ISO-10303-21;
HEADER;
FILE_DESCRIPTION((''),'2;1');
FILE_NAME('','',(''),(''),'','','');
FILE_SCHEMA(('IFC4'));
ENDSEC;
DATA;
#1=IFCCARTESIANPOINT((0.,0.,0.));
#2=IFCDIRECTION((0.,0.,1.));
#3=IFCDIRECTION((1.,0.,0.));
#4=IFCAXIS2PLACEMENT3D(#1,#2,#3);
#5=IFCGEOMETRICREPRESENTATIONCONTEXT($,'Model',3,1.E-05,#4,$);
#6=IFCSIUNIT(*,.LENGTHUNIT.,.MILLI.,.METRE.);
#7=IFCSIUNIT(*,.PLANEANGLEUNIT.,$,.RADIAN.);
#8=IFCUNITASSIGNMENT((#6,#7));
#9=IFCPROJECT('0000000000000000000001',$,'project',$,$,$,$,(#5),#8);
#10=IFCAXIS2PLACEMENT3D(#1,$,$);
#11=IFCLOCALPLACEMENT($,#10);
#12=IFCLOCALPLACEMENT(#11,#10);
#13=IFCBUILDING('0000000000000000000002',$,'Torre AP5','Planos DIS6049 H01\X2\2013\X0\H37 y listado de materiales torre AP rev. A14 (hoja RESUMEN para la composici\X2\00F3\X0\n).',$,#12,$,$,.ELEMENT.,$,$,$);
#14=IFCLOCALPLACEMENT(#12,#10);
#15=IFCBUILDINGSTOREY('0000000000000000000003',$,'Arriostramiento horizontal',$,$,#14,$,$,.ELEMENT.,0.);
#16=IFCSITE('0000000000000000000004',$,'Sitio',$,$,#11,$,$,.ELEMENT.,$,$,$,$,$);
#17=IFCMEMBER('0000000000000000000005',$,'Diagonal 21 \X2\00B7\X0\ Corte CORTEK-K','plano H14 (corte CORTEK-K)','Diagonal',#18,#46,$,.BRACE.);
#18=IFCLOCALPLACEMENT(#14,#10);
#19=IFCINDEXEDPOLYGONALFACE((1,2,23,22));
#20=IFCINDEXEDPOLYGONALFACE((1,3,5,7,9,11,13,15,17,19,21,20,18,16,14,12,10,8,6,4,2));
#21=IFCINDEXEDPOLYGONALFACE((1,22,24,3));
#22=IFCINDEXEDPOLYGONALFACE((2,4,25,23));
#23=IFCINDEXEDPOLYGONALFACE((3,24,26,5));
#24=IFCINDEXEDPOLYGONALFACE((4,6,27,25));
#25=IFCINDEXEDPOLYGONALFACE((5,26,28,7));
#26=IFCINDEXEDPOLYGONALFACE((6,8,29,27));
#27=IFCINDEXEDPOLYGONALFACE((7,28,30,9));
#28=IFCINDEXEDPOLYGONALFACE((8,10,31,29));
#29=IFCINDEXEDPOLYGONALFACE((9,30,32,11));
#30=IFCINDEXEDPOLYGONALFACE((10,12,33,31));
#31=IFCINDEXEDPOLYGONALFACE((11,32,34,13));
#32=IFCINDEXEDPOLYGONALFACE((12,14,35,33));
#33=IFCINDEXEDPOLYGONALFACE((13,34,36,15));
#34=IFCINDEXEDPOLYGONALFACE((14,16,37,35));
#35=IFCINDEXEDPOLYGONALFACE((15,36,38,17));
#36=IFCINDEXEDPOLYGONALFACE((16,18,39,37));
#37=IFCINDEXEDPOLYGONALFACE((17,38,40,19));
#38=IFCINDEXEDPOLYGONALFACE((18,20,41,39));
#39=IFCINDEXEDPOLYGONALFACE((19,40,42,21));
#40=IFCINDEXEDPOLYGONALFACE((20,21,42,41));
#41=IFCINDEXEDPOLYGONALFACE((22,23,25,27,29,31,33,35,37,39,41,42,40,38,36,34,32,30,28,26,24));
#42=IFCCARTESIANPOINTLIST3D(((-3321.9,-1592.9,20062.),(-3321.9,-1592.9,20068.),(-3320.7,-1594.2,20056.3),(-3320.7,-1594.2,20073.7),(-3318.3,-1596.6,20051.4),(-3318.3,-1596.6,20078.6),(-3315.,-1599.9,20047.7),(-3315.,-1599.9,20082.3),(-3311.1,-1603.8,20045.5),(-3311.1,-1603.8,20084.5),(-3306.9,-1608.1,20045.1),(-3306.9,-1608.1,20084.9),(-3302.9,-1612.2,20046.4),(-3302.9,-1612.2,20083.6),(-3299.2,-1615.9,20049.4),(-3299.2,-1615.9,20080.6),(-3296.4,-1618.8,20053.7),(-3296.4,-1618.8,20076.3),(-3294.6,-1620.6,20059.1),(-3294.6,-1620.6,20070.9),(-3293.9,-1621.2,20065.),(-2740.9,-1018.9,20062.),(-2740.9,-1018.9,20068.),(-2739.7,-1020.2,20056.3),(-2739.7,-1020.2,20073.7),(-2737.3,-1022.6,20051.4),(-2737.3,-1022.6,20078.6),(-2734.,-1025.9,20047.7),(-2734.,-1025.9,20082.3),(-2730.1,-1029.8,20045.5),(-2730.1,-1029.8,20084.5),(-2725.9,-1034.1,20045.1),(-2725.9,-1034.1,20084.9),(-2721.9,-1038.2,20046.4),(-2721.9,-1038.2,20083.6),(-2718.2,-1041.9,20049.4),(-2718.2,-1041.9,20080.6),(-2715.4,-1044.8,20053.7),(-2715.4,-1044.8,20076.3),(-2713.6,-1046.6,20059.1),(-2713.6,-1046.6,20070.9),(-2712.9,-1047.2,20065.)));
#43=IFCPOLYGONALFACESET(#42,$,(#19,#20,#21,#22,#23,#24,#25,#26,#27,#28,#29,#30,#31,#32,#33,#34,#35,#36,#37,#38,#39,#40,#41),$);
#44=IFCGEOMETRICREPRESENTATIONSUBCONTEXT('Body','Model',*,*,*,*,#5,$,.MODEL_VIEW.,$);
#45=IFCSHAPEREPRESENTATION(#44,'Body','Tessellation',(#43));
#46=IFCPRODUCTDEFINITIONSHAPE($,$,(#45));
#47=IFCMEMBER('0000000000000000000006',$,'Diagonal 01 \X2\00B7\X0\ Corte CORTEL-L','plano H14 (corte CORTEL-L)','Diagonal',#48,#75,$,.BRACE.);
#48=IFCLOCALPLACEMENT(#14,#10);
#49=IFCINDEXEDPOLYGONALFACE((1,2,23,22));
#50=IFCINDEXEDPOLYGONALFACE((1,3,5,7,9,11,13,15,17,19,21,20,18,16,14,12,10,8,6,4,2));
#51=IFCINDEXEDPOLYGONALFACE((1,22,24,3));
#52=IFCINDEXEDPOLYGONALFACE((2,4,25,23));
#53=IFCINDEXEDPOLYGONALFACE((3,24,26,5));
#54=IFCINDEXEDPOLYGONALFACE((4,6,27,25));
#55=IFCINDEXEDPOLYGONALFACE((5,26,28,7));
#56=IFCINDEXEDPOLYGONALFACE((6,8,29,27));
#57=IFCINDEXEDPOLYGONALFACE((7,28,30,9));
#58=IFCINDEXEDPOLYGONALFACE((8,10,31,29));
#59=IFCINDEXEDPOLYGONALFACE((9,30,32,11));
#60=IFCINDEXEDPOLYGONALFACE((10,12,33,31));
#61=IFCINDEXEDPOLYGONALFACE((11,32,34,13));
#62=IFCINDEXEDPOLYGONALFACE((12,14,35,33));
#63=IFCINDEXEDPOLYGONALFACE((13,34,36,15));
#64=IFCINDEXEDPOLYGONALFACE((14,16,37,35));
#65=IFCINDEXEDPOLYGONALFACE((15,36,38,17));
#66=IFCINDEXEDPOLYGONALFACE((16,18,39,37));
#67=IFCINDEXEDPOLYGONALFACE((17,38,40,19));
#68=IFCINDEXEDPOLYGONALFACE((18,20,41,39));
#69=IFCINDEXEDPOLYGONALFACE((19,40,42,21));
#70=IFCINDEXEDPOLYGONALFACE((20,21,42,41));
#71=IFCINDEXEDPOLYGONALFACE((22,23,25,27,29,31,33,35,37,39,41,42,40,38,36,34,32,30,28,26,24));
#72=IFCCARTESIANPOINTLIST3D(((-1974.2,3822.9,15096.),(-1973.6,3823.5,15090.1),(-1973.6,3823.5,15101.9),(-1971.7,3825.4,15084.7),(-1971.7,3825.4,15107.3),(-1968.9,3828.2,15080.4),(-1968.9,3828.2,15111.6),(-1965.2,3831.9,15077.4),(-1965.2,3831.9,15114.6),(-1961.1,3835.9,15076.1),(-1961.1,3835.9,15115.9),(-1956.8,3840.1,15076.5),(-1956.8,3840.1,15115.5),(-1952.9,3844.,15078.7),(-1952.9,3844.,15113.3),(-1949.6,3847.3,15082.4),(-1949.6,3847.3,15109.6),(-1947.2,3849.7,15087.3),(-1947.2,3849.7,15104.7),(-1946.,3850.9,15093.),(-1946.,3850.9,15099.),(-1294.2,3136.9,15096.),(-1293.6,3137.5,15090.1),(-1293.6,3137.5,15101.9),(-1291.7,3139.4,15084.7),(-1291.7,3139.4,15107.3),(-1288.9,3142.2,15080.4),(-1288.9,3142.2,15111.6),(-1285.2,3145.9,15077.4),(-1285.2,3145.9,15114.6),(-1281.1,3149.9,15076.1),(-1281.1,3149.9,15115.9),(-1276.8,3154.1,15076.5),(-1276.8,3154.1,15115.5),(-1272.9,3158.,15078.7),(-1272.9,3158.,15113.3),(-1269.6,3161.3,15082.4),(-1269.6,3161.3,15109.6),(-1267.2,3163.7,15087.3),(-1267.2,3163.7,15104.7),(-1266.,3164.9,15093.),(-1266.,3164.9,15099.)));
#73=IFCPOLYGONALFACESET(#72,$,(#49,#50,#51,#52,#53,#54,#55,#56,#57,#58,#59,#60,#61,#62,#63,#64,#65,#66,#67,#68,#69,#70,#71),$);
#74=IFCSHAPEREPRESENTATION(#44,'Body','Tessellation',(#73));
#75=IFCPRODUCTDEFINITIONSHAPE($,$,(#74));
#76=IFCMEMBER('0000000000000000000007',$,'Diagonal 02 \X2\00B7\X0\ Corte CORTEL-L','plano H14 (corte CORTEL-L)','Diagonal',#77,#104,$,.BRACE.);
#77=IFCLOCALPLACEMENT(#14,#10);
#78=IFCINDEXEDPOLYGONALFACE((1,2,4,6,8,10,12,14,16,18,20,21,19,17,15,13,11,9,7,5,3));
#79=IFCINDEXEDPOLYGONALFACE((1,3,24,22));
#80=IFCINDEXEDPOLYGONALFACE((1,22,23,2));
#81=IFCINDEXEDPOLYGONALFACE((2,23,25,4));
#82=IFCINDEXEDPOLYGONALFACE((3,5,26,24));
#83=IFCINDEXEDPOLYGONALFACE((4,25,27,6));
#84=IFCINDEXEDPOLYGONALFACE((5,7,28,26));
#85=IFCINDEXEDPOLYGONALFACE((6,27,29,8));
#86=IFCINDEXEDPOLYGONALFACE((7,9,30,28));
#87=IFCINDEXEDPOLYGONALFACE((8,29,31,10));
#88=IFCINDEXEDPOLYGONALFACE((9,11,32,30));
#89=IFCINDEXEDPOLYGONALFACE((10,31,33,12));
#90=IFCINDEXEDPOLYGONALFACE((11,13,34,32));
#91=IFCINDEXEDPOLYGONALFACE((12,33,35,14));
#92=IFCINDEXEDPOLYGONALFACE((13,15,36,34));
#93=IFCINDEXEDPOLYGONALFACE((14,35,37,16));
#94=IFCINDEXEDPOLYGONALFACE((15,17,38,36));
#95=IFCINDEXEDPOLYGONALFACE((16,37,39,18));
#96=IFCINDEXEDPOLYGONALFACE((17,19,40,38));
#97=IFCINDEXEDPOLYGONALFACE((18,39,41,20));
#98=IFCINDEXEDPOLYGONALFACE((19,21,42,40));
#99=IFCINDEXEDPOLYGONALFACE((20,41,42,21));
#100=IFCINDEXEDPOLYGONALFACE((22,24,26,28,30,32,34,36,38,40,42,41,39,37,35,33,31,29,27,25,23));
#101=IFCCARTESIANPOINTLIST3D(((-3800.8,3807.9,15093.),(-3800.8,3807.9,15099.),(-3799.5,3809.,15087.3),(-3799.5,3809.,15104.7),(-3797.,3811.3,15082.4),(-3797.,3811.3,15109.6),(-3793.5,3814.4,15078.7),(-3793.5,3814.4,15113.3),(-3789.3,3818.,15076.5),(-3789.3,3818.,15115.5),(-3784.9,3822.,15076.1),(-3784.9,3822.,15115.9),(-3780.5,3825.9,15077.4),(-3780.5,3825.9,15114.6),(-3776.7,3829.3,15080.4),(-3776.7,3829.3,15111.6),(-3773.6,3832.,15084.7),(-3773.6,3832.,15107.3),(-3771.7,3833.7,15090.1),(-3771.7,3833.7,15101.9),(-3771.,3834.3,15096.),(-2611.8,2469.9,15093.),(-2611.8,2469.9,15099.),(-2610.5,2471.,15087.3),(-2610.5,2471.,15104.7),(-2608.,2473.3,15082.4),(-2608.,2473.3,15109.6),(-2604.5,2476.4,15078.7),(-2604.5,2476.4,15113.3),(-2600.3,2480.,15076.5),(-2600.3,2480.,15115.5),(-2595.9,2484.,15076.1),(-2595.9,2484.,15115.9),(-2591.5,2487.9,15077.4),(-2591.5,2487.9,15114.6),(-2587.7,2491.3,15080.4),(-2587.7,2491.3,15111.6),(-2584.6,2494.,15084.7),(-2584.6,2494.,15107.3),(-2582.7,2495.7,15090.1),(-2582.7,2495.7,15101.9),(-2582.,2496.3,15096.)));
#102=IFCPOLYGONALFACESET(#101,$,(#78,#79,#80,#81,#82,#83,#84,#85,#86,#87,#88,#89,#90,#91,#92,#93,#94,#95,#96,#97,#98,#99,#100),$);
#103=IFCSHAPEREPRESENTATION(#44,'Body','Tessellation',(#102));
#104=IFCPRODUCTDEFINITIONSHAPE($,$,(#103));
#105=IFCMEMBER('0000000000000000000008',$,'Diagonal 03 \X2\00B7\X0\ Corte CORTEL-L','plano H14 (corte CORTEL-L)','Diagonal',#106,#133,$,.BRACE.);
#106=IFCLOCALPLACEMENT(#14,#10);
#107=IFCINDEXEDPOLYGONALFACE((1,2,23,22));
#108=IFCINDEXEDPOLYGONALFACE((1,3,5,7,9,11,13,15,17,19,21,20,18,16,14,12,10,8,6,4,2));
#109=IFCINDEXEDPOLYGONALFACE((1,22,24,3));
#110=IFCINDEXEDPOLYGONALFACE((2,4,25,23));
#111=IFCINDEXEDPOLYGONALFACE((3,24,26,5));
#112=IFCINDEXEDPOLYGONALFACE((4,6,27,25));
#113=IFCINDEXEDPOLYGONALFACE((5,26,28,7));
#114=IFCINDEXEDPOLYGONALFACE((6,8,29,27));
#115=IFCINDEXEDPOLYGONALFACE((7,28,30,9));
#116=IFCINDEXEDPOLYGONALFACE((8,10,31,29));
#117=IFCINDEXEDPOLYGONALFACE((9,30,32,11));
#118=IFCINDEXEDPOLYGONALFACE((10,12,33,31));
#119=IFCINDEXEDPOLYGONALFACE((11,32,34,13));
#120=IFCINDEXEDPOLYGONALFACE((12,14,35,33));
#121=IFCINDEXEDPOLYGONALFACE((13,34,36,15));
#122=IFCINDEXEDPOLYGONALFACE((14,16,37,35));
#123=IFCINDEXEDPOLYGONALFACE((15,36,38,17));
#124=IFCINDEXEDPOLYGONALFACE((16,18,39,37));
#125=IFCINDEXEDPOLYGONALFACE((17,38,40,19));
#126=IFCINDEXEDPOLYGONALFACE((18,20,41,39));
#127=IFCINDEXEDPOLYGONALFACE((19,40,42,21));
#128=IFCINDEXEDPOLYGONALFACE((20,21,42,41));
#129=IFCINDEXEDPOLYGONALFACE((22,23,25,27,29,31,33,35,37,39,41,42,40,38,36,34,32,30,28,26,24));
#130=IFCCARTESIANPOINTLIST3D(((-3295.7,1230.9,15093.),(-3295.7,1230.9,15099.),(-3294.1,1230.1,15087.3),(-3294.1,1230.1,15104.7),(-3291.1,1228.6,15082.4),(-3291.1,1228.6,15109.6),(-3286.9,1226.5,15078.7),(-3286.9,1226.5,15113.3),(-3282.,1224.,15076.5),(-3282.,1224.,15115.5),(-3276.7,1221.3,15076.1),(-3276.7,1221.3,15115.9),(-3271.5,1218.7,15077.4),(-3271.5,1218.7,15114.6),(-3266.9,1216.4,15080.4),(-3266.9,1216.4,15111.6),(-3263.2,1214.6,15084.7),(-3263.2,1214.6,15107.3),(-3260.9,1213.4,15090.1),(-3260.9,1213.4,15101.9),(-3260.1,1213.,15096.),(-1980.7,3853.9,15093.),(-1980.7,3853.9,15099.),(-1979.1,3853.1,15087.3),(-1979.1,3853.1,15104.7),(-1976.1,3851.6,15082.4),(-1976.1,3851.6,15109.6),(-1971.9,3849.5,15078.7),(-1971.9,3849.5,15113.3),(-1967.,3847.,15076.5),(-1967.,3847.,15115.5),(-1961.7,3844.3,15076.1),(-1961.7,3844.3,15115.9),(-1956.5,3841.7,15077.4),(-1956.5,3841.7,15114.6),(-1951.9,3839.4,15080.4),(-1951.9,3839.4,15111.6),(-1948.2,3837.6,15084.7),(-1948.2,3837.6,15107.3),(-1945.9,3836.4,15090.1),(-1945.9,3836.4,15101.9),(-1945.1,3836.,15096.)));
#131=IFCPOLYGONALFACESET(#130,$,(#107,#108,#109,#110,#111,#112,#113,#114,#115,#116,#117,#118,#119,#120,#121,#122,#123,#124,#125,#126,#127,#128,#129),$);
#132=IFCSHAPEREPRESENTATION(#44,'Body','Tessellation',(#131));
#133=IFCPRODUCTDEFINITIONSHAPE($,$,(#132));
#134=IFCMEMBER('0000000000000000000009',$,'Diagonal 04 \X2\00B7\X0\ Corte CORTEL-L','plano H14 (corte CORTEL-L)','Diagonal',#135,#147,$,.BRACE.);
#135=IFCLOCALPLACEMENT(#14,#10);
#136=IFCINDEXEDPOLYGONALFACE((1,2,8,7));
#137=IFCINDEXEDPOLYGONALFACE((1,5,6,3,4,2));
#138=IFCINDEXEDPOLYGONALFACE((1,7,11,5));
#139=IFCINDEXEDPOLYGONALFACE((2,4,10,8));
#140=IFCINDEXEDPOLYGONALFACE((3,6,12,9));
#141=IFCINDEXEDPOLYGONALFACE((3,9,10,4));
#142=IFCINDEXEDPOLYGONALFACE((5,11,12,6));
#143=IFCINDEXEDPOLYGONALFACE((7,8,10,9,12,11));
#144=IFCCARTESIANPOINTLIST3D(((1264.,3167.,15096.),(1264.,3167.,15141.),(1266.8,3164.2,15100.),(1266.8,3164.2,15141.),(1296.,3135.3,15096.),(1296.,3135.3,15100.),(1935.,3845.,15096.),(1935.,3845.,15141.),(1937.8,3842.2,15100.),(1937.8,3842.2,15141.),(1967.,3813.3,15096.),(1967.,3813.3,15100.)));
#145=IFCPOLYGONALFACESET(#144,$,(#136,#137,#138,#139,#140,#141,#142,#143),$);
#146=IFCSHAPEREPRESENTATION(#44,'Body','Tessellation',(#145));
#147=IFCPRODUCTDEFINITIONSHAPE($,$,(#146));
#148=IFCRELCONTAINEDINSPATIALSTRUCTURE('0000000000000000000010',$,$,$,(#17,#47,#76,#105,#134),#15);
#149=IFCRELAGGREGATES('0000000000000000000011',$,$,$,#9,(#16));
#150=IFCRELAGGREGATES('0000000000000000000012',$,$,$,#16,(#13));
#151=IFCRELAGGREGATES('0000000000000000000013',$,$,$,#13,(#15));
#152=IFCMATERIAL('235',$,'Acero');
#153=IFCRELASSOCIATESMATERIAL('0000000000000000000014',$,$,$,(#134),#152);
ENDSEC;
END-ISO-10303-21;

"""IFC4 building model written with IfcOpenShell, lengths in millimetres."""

from ifc_helpers import new_model, si_unit, frame, frame_2d, origin, origin_with_axes, place, context, subcontext, project, spatial, circle, l_section, extrude, material, element, save


model = new_model("IFC4")

# Units and contexts
model_context = context("Model", 3, precision=1e-05, world=origin_with_axes())
body_context = subcontext(model_context, "Body", "Model", "MODEL_VIEW")
ifc_project = project(units=[si_unit("LENGTHUNIT", "METRE", prefix="MILLI"), si_unit("PLANEANGLEUNIT", "RADIAN")], contexts=[model_context])

# Site, building, storey
site_placement = place(None, origin())
site = spatial("IfcSite", under=ifc_project, at=site_placement, Name="Sitio", CompositionType="ELEMENT")
building_placement = place(site_placement, origin())
building = spatial("IfcBuilding", under=site, at=building_placement, Name="Torre AP5", Description="Planos DIS6049 H01–H37 y listado de materiales torre AP rev. A14 (hoja RESUMEN para la composición).", CompositionType="ELEMENT")
storey_placement = place(building_placement, origin())
storey = spatial("IfcBuildingStorey", under=building, at=storey_placement, Name="Arriostramiento horizontal", CompositionType="ELEMENT", Elevation=0.0)

# Members
ifc_material = material(Name="235", Category="Acero")
for number, where, z_axis, x_axis, name in (
    (1, (-2727.0, -1033.0, 20065.0), (-0.711379, -0.702808, 0.0), (0.702808, -0.711379, 0.0), "Diagonal 21 · Corte CORTEK-K"),
):
    element("IfcMember", number, at=place(storey_placement, frame(where, z_axis=z_axis, x_axis=x_axis)), inside=storey, Name=name, Description="plano H14 (corte CORTEK-K)", ObjectType="Diagonal", PredefinedType="BRACE", context=body_context, shape_type="SweptSolid", body=[
        extrude(circle(Radius=20.0), None, (0.0, 0.0, 1.0), 816.7),
    ])
member_1_placement = place(storey_placement, frame((-1960.0, 3837.0, 15096.0), z_axis=(0.703994, -0.710206, 0.0), x_axis=(-0.710206, -0.703994, 0.0)))
element("IfcMember", 2, at=member_1_placement, inside=storey, Name="Diagonal 01 · Corte CORTEL-L", Description="plano H14 (corte CORTEL-L)", ObjectType="Diagonal", PredefinedType="BRACE", context=body_context, shape_type="SweptSolid", body=[
    extrude(circle(Radius=20.0), None, (0.0, 0.0, 1.0), 965.9),
])
member_2_placement = place(storey_placement, frame((-3786.0, 3821.0, 15096.0), z_axis=(0.66426, -0.747502, 0.0), x_axis=(0.747502, 0.66426, 0.0)))
element("IfcMember", 3, at=member_2_placement, inside=storey, Name="Diagonal 02 · Corte CORTEL-L", Description="plano H14 (corte CORTEL-L)", ObjectType="Diagonal", PredefinedType="BRACE", context=body_context, shape_type="SweptSolid", body=[
    extrude(circle(Radius=20.0), None, (0.0, 0.0, 1.0), 1790.0),
])
member_3_placement = place(storey_placement, frame((-1963.0, 3845.0, 15096.0), z_axis=(-0.448168, -0.89395, 0.0), x_axis=(0.89395, -0.448168, 0.0)))
element("IfcMember", 4, at=member_3_placement, inside=storey, Name="Diagonal 03 · Corte CORTEL-L", Description="plano H14 (corte CORTEL-L)", ObjectType="Diagonal", PredefinedType="BRACE", context=body_context, shape_type="SweptSolid", body=[
    extrude(circle(Radius=20.0), None, (0.0, 0.0, 1.0), 2934.2),
])
member_4_placement = place(storey_placement, frame((1935.0, 3845.0, 15096.0), z_axis=(-0.703428, -0.710766, 0.0), x_axis=(0.710766, -0.703428, 0.0)))
element("IfcMember", 5, at=member_4_placement, inside=storey, material=ifc_material, Name="Diagonal 04 · Corte CORTEL-L", Description="plano H14 (corte CORTEL-L)", ObjectType="Diagonal", PredefinedType="BRACE", context=body_context, shape_type="SweptSolid", body=[
    extrude(l_section(Depth=45.0, Width=45.0, Thickness=4.0, at=frame_2d((22.5, 22.5))), None, (0.0, 0.0, 1.0), 953.9),
])

save(model, "model.ifc")
